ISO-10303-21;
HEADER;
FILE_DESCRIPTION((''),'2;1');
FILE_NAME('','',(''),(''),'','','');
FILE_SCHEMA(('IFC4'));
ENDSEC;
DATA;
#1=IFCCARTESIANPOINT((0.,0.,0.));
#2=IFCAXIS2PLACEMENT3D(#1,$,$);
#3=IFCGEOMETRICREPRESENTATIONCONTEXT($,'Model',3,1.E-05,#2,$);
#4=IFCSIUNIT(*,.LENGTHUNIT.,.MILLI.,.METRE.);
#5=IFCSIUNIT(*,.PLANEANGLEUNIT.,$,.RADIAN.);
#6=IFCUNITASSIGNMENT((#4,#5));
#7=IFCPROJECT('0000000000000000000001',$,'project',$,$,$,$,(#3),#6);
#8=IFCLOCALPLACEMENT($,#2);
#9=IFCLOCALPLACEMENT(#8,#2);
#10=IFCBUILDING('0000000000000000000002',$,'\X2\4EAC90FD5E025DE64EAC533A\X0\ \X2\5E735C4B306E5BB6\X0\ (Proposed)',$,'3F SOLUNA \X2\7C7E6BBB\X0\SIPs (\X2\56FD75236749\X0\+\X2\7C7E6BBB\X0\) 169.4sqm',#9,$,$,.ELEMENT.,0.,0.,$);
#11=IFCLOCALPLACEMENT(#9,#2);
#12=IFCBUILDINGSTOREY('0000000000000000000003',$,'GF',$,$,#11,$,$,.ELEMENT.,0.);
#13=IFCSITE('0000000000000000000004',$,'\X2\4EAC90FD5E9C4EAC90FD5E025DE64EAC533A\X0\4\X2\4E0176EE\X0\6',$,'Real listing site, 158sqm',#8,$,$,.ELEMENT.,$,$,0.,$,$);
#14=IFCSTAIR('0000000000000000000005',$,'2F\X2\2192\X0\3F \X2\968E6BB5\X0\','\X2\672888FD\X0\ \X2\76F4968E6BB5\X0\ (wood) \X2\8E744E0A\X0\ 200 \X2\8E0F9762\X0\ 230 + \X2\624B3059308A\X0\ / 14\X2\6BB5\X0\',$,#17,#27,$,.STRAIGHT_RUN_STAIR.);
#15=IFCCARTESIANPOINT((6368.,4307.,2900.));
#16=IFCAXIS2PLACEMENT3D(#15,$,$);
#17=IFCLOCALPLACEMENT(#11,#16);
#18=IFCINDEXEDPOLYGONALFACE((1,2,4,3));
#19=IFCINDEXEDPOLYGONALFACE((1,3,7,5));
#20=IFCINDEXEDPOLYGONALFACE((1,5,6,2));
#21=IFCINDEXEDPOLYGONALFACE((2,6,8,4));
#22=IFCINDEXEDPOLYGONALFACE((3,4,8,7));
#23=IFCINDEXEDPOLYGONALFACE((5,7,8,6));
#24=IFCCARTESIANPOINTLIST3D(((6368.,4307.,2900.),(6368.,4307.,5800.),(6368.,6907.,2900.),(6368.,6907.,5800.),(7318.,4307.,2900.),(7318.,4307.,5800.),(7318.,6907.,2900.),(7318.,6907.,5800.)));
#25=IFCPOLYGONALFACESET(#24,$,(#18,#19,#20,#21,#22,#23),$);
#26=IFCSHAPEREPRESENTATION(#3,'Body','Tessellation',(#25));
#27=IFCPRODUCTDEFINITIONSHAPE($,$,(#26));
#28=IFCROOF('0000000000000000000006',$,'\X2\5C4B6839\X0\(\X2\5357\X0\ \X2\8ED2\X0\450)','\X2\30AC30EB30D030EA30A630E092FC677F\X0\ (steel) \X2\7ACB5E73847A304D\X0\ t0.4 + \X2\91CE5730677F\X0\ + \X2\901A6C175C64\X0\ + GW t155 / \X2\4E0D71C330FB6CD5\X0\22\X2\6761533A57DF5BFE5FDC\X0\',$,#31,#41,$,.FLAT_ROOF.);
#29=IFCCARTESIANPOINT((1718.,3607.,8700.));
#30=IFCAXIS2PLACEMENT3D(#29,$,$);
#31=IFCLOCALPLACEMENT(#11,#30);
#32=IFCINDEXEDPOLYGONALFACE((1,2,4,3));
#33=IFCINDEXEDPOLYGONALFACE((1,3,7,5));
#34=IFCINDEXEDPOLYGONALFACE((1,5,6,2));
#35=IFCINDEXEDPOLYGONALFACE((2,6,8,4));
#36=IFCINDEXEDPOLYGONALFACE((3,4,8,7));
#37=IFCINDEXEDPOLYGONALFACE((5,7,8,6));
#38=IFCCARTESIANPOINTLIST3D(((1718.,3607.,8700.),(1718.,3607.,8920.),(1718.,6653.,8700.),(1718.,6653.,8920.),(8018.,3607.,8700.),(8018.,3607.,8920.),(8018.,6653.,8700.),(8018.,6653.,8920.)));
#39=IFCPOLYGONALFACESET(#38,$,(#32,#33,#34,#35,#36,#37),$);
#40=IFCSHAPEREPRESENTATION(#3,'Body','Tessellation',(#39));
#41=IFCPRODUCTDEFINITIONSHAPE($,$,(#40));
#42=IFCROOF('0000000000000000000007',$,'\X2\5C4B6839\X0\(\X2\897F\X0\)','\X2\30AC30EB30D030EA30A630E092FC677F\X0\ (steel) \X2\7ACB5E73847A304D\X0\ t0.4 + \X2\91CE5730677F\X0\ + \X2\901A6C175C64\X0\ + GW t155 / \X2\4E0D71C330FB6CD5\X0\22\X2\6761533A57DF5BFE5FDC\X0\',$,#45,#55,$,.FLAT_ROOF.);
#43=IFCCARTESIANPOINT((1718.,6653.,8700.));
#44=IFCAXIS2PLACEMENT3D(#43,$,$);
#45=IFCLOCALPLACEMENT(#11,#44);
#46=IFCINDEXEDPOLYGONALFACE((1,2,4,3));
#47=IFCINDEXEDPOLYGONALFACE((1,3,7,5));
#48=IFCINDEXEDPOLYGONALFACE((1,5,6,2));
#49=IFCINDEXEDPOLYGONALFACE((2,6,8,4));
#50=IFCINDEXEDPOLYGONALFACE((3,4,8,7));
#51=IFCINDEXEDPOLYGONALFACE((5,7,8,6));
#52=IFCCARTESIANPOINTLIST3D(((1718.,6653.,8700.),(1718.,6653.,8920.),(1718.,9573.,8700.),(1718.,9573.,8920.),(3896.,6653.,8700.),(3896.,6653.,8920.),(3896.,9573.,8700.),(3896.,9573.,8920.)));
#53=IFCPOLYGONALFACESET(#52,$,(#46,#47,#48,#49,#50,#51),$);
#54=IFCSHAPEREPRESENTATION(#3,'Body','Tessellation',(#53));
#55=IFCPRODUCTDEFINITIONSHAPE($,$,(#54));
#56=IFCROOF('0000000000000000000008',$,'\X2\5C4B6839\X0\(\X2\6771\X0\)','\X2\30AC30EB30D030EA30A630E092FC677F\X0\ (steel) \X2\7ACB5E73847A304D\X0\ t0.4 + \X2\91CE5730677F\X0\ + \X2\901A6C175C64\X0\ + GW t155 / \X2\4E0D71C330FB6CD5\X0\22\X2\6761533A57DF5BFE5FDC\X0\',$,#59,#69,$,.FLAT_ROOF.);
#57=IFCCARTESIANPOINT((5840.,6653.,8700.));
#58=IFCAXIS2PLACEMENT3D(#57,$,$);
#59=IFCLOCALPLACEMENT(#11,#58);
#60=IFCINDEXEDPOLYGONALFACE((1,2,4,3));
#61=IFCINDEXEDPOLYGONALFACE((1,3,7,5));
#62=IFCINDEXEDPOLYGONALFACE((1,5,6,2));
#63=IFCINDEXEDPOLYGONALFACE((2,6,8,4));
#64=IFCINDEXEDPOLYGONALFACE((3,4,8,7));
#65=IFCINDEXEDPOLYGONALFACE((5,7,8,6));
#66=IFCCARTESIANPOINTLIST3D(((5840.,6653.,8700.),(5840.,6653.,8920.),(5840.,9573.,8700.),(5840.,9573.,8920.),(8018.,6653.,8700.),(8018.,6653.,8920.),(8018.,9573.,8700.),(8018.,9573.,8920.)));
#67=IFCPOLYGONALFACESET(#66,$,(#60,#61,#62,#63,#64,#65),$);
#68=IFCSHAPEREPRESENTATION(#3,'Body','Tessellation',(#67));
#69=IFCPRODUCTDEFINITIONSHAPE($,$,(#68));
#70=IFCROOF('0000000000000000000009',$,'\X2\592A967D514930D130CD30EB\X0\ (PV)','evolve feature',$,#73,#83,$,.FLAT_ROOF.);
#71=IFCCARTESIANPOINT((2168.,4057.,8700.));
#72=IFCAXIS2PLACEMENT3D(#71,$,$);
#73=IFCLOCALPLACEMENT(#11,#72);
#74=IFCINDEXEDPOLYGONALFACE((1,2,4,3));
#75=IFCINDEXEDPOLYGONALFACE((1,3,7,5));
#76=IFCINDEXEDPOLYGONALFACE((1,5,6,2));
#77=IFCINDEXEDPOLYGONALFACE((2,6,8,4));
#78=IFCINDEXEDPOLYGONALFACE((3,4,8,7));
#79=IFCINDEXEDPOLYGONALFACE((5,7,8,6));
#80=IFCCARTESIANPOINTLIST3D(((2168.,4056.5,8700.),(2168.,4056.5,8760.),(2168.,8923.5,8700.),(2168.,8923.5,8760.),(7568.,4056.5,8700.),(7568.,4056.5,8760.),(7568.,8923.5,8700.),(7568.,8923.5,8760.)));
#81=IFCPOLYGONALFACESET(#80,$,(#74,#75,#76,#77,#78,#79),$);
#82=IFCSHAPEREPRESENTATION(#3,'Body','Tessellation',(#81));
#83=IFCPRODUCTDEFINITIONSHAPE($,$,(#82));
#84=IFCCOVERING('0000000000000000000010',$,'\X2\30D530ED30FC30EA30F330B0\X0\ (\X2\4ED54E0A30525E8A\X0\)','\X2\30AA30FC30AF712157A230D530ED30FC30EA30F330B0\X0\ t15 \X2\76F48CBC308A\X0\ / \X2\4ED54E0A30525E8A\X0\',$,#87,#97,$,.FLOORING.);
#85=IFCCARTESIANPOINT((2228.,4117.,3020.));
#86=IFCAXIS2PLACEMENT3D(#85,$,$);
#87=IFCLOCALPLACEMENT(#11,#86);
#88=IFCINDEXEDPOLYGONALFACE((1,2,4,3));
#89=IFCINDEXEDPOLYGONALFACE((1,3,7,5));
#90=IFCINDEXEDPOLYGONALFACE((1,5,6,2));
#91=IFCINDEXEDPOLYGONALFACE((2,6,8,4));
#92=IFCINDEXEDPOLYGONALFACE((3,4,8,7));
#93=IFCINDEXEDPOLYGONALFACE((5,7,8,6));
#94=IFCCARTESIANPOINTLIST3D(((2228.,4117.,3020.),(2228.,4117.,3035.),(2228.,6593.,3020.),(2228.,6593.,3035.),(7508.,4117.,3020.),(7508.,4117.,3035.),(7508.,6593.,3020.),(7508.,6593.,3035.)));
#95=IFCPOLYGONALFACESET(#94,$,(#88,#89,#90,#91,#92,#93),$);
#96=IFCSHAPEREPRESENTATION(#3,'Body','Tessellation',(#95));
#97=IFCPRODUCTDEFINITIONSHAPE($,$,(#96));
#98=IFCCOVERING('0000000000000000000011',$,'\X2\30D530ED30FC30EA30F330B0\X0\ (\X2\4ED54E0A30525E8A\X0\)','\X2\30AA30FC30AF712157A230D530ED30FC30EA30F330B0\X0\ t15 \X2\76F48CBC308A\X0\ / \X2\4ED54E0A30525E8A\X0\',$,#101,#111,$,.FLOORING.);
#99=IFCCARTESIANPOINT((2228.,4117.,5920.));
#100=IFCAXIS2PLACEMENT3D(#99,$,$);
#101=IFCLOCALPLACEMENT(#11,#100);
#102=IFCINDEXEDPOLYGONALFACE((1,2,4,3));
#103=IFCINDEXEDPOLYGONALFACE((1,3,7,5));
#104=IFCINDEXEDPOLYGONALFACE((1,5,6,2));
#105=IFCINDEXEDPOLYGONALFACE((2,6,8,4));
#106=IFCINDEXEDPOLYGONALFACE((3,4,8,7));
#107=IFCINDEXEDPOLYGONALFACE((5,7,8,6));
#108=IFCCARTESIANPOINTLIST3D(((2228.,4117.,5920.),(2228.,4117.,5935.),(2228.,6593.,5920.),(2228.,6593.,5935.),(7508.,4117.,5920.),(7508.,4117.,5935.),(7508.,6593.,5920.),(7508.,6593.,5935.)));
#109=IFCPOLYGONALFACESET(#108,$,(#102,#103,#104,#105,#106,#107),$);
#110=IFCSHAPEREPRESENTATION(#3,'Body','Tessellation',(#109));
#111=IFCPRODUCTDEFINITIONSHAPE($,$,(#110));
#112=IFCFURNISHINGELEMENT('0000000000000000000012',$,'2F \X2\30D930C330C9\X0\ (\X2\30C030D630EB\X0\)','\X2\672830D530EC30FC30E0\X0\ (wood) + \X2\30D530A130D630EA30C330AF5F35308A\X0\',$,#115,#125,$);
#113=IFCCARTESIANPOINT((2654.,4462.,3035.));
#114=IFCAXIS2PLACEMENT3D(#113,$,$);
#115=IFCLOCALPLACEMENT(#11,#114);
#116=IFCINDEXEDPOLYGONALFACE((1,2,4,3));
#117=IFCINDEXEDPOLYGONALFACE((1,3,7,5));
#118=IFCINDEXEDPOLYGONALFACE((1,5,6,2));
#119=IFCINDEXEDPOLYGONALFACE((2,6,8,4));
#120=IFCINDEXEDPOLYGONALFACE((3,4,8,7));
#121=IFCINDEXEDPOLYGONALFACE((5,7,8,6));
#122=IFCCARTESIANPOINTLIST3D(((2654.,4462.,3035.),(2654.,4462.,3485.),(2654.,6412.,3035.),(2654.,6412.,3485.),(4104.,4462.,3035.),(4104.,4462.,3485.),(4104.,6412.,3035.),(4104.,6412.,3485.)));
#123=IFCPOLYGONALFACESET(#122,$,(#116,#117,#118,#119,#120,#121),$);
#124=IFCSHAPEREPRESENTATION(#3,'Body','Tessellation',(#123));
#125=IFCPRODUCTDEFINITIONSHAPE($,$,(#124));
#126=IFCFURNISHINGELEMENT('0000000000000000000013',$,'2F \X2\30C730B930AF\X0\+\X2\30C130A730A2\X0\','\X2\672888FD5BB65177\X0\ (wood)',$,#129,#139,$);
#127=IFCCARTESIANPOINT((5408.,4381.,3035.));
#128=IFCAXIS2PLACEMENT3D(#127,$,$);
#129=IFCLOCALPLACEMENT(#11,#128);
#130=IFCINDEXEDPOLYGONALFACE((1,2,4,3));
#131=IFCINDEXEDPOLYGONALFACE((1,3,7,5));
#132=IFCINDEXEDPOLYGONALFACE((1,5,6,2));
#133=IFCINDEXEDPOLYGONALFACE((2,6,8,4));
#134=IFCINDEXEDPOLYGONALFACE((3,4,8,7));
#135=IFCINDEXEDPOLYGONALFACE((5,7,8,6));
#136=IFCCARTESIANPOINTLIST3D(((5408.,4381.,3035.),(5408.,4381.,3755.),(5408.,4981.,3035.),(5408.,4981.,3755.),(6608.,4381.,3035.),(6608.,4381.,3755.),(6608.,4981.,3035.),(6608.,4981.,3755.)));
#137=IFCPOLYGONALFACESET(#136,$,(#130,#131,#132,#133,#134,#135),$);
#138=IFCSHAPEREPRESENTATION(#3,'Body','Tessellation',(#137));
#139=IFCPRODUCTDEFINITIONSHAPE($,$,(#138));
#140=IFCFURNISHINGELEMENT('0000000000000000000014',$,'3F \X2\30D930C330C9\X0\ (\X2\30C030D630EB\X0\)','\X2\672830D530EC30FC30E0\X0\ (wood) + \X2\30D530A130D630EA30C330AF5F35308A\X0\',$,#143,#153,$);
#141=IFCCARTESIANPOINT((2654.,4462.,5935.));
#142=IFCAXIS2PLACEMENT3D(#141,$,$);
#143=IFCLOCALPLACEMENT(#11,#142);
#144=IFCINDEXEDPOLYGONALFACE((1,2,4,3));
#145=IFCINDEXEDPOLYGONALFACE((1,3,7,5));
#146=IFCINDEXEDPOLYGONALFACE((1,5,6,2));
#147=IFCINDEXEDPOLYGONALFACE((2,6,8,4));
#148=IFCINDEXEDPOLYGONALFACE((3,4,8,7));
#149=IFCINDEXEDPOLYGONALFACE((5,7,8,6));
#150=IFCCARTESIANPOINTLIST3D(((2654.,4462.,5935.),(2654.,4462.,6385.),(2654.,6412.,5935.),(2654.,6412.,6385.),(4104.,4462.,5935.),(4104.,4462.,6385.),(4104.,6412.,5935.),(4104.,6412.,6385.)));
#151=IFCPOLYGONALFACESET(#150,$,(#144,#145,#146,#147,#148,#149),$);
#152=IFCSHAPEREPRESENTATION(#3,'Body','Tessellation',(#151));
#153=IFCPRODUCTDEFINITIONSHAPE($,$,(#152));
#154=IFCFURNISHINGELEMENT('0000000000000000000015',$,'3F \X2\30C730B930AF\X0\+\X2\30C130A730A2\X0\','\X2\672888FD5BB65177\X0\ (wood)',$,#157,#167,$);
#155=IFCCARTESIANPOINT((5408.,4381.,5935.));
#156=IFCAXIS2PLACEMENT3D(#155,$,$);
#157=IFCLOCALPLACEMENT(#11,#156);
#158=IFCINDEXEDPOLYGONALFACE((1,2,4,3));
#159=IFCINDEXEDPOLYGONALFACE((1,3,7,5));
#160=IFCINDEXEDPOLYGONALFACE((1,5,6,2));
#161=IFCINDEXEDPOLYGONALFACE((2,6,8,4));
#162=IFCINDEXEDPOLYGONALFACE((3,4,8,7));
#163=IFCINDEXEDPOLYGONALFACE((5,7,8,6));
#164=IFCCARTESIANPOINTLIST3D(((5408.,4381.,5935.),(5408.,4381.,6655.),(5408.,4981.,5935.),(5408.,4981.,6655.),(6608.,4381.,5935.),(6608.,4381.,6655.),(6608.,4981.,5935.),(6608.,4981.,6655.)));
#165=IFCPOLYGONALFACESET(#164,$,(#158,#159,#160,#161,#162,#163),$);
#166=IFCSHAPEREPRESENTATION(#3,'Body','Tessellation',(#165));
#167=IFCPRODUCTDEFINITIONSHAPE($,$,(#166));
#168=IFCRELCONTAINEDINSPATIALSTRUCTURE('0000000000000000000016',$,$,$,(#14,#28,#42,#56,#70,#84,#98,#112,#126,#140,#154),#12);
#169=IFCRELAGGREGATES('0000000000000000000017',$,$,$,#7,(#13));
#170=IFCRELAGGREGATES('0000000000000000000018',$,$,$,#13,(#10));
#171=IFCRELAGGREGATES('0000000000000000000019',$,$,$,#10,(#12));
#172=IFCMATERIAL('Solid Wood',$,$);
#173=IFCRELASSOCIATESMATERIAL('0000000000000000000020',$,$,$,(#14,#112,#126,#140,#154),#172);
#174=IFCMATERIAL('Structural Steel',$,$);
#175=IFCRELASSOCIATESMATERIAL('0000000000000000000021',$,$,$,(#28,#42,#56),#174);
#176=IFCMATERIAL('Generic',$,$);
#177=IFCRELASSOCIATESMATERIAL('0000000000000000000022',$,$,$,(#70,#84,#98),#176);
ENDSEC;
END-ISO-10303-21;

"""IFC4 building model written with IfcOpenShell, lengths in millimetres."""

from ifc_helpers import new_model, si_unit, frame, frame_2d, origin, place, context, project, spatial, rectangle, extrude, material, element, save


model = new_model("IFC4")

# Units and contexts
model_context = context("Model", 3, precision=1e-05, world=origin())
ifc_project = project(units=[si_unit("LENGTHUNIT", "METRE", prefix="MILLI"), si_unit("PLANEANGLEUNIT", "RADIAN")], contexts=[model_context])

# Site, building, storey
site_placement = place(None, origin())
site = spatial("IfcSite", under=ifc_project, at=site_placement, Name="京都府京都市左京区4丁目6", ObjectType="Real listing site, 158sqm", CompositionType="ELEMENT", RefElevation=0.0)
building_placement = place(site_placement, origin())
building = spatial("IfcBuilding", under=site, at=building_placement, Name="京都市左京区 平屋の家 (Proposed)", ObjectType="3F SOLUNA 籾殻SIPs (国産杉+籾殻) 169.4sqm", CompositionType="ELEMENT", ElevationOfRefHeight=0.0, ElevationOfTerrain=0.0)
storey_placement = place(building_placement, origin())
storey = spatial("IfcBuildingStorey", under=building, at=storey_placement, Name="GF", CompositionType="ELEMENT", Elevation=0.0)

# Shared definitions
ifc_material_1 = material(Name="Solid Wood")

# Stair
stair_placement = place(storey_placement, frame((6368.0, 4307.0, 2900.0)))
element("IfcStair", 1, at=stair_placement, inside=storey, material=ifc_material_1, Name="2F→3F 階段", Description="木製 直階段 (wood) 蹴上 200 踏面 230 + 手すり / 14段", PredefinedType="STRAIGHT_RUN_STAIR", context=model_context, shape_type="SweptSolid", body=[
    extrude(rectangle(XDim=950.0, YDim=2600.0, at=frame_2d((475.0, 1300.0))), frame((6368.0, 4307.0, 2900.0)), (0.0, 0.0, 1.0), 2900.0),
])

# Roofs
ifc_material_2 = material(Name="Structural Steel")
roof_1_placement = place(storey_placement, frame((1718.0, 3607.0, 8700.0)))
element("IfcRoof", 2, at=roof_1_placement, inside=storey, material=ifc_material_2, Name="屋根(南 軒450)", Description="ガルバリウム鋼板 (steel) 立平葺き t0.4 + 野地板 + 通気層 + GW t155 / 不燃・法22条区域対応", PredefinedType="FLAT_ROOF", context=model_context, shape_type="SweptSolid", body=[
    extrude(rectangle(XDim=6300.0, YDim=3046.0, at=frame_2d((3150.0, 1523.0))), frame((1718.0, 3607.0, 8700.0)), (0.0, 0.0, 1.0), 220.0),
])
roof_2_placement = place(storey_placement, frame((1718.0, 6653.0, 8700.0)))
element("IfcRoof", 3, at=roof_2_placement, inside=storey, material=ifc_material_2, Name="屋根(西)", Description="ガルバリウム鋼板 (steel) 立平葺き t0.4 + 野地板 + 通気層 + GW t155 / 不燃・法22条区域対応", PredefinedType="FLAT_ROOF", context=model_context, shape_type="SweptSolid", body=[
    extrude(rectangle(XDim=2178.0, YDim=2920.0, at=frame_2d((1089.0, 1460.0))), frame((1718.0, 6653.0, 8700.0)), (0.0, 0.0, 1.0), 220.0),
])
roof_3_placement = place(storey_placement, frame((5840.0, 6653.0, 8700.0)))
element("IfcRoof", 4, at=roof_3_placement, inside=storey, material=ifc_material_2, Name="屋根(東)", Description="ガルバリウム鋼板 (steel) 立平葺き t0.4 + 野地板 + 通気層 + GW t155 / 不燃・法22条区域対応", PredefinedType="FLAT_ROOF", context=model_context, shape_type="SweptSolid", body=[
    extrude(rectangle(XDim=2178.0, YDim=2920.0, at=frame_2d((1089.0, 1460.0))), frame((5840.0, 6653.0, 8700.0)), (0.0, 0.0, 1.0), 220.0),
])
ifc_material_3 = material(Name="Generic")
roof_4_placement = place(storey_placement, frame((2168.0, 4057.0, 8700.0)))
element("IfcRoof", 5, at=roof_4_placement, inside=storey, material=ifc_material_3, Name="太陽光パネル (PV)", Description="evolve feature", PredefinedType="FLAT_ROOF", context=model_context, shape_type="SweptSolid", body=[
    extrude(rectangle(XDim=5400.0, YDim=4867.0, at=frame_2d((2700.0, 2433.0))), frame((2168.0, 4057.0, 8700.0)), (0.0, 0.0, 1.0), 60.0),
])

# Coverings
covering_1_placement = place(storey_placement, frame((2228.0, 4117.0, 3020.0)))
element("IfcCovering", 6, at=covering_1_placement, inside=storey, material=ifc_material_3, Name="フローリング (仕上げ床)", Description="オーク無垢フローリング t15 直貼り / 仕上げ床", PredefinedType="FLOORING", context=model_context, shape_type="SweptSolid", body=[
    extrude(rectangle(XDim=5280.0, YDim=2476.0, at=frame_2d((2640.0, 1238.0))), frame((2228.0, 4117.0, 3020.0)), (0.0, 0.0, 1.0), 15.0),
])
covering_2_placement = place(storey_placement, frame((2228.0, 4117.0, 5920.0)))
element("IfcCovering", 7, at=covering_2_placement, inside=storey, material=ifc_material_3, Name="フローリング (仕上げ床)", Description="オーク無垢フローリング t15 直貼り / 仕上げ床", PredefinedType="FLOORING", context=model_context, shape_type="SweptSolid", body=[
    extrude(rectangle(XDim=5280.0, YDim=2476.0, at=frame_2d((2640.0, 1238.0))), frame((2228.0, 4117.0, 5920.0)), (0.0, 0.0, 1.0), 15.0),
])

# Furnishing elements
furnishing_1_placement = place(storey_placement, frame((2654.0, 4462.0, 3035.0)))
element("IfcFurnishingElement", 8, at=furnishing_1_placement, inside=storey, material=ifc_material_1, Name="2F ベッド (ダブル)", Description="木フレーム (wood) + ファブリック張り", context=model_context, shape_type="SweptSolid", body=[
    extrude(rectangle(XDim=1450.0, YDim=1950.0, at=frame_2d((725.0, 975.0))), frame((2654.0, 4462.0, 3035.0)), (0.0, 0.0, 1.0), 450.0),
])
furnishing_2_placement = place(storey_placement, frame((5408.0, 4381.0, 3035.0)))
element("IfcFurnishingElement", 9, at=furnishing_2_placement, inside=storey, material=ifc_material_1, Name="2F デスク+チェア", Description="木製家具 (wood)", context=model_context, shape_type="SweptSolid", body=[
    extrude(rectangle(XDim=1200.0, YDim=600.0, at=frame_2d((600.0, 300.0))), frame((5408.0, 4381.0, 3035.0)), (0.0, 0.0, 1.0), 720.0),
])
furnishing_3_placement = place(storey_placement, frame((2654.0, 4462.0, 5935.0)))
element("IfcFurnishingElement", 10, at=furnishing_3_placement, inside=storey, material=ifc_material_1, Name="3F ベッド (ダブル)", Description="木フレーム (wood) + ファブリック張り", context=model_context, shape_type="SweptSolid", body=[
    extrude(rectangle(XDim=1450.0, YDim=1950.0, at=frame_2d((725.0, 975.0))), frame((2654.0, 4462.0, 5935.0)), (0.0, 0.0, 1.0), 450.0),
])
furnishing_4_placement = place(storey_placement, frame((5408.0, 4381.0, 5935.0)))
element("IfcFurnishingElement", 11, at=furnishing_4_placement, inside=storey, material=ifc_material_1, Name="3F デスク+チェア", Description="木製家具 (wood)", context=model_context, shape_type="SweptSolid", body=[
    extrude(rectangle(XDim=1200.0, YDim=600.0, at=frame_2d((600.0, 300.0))), frame((5408.0, 4381.0, 5935.0)), (0.0, 0.0, 1.0), 720.0),
])

save(model, "model.ifc")
